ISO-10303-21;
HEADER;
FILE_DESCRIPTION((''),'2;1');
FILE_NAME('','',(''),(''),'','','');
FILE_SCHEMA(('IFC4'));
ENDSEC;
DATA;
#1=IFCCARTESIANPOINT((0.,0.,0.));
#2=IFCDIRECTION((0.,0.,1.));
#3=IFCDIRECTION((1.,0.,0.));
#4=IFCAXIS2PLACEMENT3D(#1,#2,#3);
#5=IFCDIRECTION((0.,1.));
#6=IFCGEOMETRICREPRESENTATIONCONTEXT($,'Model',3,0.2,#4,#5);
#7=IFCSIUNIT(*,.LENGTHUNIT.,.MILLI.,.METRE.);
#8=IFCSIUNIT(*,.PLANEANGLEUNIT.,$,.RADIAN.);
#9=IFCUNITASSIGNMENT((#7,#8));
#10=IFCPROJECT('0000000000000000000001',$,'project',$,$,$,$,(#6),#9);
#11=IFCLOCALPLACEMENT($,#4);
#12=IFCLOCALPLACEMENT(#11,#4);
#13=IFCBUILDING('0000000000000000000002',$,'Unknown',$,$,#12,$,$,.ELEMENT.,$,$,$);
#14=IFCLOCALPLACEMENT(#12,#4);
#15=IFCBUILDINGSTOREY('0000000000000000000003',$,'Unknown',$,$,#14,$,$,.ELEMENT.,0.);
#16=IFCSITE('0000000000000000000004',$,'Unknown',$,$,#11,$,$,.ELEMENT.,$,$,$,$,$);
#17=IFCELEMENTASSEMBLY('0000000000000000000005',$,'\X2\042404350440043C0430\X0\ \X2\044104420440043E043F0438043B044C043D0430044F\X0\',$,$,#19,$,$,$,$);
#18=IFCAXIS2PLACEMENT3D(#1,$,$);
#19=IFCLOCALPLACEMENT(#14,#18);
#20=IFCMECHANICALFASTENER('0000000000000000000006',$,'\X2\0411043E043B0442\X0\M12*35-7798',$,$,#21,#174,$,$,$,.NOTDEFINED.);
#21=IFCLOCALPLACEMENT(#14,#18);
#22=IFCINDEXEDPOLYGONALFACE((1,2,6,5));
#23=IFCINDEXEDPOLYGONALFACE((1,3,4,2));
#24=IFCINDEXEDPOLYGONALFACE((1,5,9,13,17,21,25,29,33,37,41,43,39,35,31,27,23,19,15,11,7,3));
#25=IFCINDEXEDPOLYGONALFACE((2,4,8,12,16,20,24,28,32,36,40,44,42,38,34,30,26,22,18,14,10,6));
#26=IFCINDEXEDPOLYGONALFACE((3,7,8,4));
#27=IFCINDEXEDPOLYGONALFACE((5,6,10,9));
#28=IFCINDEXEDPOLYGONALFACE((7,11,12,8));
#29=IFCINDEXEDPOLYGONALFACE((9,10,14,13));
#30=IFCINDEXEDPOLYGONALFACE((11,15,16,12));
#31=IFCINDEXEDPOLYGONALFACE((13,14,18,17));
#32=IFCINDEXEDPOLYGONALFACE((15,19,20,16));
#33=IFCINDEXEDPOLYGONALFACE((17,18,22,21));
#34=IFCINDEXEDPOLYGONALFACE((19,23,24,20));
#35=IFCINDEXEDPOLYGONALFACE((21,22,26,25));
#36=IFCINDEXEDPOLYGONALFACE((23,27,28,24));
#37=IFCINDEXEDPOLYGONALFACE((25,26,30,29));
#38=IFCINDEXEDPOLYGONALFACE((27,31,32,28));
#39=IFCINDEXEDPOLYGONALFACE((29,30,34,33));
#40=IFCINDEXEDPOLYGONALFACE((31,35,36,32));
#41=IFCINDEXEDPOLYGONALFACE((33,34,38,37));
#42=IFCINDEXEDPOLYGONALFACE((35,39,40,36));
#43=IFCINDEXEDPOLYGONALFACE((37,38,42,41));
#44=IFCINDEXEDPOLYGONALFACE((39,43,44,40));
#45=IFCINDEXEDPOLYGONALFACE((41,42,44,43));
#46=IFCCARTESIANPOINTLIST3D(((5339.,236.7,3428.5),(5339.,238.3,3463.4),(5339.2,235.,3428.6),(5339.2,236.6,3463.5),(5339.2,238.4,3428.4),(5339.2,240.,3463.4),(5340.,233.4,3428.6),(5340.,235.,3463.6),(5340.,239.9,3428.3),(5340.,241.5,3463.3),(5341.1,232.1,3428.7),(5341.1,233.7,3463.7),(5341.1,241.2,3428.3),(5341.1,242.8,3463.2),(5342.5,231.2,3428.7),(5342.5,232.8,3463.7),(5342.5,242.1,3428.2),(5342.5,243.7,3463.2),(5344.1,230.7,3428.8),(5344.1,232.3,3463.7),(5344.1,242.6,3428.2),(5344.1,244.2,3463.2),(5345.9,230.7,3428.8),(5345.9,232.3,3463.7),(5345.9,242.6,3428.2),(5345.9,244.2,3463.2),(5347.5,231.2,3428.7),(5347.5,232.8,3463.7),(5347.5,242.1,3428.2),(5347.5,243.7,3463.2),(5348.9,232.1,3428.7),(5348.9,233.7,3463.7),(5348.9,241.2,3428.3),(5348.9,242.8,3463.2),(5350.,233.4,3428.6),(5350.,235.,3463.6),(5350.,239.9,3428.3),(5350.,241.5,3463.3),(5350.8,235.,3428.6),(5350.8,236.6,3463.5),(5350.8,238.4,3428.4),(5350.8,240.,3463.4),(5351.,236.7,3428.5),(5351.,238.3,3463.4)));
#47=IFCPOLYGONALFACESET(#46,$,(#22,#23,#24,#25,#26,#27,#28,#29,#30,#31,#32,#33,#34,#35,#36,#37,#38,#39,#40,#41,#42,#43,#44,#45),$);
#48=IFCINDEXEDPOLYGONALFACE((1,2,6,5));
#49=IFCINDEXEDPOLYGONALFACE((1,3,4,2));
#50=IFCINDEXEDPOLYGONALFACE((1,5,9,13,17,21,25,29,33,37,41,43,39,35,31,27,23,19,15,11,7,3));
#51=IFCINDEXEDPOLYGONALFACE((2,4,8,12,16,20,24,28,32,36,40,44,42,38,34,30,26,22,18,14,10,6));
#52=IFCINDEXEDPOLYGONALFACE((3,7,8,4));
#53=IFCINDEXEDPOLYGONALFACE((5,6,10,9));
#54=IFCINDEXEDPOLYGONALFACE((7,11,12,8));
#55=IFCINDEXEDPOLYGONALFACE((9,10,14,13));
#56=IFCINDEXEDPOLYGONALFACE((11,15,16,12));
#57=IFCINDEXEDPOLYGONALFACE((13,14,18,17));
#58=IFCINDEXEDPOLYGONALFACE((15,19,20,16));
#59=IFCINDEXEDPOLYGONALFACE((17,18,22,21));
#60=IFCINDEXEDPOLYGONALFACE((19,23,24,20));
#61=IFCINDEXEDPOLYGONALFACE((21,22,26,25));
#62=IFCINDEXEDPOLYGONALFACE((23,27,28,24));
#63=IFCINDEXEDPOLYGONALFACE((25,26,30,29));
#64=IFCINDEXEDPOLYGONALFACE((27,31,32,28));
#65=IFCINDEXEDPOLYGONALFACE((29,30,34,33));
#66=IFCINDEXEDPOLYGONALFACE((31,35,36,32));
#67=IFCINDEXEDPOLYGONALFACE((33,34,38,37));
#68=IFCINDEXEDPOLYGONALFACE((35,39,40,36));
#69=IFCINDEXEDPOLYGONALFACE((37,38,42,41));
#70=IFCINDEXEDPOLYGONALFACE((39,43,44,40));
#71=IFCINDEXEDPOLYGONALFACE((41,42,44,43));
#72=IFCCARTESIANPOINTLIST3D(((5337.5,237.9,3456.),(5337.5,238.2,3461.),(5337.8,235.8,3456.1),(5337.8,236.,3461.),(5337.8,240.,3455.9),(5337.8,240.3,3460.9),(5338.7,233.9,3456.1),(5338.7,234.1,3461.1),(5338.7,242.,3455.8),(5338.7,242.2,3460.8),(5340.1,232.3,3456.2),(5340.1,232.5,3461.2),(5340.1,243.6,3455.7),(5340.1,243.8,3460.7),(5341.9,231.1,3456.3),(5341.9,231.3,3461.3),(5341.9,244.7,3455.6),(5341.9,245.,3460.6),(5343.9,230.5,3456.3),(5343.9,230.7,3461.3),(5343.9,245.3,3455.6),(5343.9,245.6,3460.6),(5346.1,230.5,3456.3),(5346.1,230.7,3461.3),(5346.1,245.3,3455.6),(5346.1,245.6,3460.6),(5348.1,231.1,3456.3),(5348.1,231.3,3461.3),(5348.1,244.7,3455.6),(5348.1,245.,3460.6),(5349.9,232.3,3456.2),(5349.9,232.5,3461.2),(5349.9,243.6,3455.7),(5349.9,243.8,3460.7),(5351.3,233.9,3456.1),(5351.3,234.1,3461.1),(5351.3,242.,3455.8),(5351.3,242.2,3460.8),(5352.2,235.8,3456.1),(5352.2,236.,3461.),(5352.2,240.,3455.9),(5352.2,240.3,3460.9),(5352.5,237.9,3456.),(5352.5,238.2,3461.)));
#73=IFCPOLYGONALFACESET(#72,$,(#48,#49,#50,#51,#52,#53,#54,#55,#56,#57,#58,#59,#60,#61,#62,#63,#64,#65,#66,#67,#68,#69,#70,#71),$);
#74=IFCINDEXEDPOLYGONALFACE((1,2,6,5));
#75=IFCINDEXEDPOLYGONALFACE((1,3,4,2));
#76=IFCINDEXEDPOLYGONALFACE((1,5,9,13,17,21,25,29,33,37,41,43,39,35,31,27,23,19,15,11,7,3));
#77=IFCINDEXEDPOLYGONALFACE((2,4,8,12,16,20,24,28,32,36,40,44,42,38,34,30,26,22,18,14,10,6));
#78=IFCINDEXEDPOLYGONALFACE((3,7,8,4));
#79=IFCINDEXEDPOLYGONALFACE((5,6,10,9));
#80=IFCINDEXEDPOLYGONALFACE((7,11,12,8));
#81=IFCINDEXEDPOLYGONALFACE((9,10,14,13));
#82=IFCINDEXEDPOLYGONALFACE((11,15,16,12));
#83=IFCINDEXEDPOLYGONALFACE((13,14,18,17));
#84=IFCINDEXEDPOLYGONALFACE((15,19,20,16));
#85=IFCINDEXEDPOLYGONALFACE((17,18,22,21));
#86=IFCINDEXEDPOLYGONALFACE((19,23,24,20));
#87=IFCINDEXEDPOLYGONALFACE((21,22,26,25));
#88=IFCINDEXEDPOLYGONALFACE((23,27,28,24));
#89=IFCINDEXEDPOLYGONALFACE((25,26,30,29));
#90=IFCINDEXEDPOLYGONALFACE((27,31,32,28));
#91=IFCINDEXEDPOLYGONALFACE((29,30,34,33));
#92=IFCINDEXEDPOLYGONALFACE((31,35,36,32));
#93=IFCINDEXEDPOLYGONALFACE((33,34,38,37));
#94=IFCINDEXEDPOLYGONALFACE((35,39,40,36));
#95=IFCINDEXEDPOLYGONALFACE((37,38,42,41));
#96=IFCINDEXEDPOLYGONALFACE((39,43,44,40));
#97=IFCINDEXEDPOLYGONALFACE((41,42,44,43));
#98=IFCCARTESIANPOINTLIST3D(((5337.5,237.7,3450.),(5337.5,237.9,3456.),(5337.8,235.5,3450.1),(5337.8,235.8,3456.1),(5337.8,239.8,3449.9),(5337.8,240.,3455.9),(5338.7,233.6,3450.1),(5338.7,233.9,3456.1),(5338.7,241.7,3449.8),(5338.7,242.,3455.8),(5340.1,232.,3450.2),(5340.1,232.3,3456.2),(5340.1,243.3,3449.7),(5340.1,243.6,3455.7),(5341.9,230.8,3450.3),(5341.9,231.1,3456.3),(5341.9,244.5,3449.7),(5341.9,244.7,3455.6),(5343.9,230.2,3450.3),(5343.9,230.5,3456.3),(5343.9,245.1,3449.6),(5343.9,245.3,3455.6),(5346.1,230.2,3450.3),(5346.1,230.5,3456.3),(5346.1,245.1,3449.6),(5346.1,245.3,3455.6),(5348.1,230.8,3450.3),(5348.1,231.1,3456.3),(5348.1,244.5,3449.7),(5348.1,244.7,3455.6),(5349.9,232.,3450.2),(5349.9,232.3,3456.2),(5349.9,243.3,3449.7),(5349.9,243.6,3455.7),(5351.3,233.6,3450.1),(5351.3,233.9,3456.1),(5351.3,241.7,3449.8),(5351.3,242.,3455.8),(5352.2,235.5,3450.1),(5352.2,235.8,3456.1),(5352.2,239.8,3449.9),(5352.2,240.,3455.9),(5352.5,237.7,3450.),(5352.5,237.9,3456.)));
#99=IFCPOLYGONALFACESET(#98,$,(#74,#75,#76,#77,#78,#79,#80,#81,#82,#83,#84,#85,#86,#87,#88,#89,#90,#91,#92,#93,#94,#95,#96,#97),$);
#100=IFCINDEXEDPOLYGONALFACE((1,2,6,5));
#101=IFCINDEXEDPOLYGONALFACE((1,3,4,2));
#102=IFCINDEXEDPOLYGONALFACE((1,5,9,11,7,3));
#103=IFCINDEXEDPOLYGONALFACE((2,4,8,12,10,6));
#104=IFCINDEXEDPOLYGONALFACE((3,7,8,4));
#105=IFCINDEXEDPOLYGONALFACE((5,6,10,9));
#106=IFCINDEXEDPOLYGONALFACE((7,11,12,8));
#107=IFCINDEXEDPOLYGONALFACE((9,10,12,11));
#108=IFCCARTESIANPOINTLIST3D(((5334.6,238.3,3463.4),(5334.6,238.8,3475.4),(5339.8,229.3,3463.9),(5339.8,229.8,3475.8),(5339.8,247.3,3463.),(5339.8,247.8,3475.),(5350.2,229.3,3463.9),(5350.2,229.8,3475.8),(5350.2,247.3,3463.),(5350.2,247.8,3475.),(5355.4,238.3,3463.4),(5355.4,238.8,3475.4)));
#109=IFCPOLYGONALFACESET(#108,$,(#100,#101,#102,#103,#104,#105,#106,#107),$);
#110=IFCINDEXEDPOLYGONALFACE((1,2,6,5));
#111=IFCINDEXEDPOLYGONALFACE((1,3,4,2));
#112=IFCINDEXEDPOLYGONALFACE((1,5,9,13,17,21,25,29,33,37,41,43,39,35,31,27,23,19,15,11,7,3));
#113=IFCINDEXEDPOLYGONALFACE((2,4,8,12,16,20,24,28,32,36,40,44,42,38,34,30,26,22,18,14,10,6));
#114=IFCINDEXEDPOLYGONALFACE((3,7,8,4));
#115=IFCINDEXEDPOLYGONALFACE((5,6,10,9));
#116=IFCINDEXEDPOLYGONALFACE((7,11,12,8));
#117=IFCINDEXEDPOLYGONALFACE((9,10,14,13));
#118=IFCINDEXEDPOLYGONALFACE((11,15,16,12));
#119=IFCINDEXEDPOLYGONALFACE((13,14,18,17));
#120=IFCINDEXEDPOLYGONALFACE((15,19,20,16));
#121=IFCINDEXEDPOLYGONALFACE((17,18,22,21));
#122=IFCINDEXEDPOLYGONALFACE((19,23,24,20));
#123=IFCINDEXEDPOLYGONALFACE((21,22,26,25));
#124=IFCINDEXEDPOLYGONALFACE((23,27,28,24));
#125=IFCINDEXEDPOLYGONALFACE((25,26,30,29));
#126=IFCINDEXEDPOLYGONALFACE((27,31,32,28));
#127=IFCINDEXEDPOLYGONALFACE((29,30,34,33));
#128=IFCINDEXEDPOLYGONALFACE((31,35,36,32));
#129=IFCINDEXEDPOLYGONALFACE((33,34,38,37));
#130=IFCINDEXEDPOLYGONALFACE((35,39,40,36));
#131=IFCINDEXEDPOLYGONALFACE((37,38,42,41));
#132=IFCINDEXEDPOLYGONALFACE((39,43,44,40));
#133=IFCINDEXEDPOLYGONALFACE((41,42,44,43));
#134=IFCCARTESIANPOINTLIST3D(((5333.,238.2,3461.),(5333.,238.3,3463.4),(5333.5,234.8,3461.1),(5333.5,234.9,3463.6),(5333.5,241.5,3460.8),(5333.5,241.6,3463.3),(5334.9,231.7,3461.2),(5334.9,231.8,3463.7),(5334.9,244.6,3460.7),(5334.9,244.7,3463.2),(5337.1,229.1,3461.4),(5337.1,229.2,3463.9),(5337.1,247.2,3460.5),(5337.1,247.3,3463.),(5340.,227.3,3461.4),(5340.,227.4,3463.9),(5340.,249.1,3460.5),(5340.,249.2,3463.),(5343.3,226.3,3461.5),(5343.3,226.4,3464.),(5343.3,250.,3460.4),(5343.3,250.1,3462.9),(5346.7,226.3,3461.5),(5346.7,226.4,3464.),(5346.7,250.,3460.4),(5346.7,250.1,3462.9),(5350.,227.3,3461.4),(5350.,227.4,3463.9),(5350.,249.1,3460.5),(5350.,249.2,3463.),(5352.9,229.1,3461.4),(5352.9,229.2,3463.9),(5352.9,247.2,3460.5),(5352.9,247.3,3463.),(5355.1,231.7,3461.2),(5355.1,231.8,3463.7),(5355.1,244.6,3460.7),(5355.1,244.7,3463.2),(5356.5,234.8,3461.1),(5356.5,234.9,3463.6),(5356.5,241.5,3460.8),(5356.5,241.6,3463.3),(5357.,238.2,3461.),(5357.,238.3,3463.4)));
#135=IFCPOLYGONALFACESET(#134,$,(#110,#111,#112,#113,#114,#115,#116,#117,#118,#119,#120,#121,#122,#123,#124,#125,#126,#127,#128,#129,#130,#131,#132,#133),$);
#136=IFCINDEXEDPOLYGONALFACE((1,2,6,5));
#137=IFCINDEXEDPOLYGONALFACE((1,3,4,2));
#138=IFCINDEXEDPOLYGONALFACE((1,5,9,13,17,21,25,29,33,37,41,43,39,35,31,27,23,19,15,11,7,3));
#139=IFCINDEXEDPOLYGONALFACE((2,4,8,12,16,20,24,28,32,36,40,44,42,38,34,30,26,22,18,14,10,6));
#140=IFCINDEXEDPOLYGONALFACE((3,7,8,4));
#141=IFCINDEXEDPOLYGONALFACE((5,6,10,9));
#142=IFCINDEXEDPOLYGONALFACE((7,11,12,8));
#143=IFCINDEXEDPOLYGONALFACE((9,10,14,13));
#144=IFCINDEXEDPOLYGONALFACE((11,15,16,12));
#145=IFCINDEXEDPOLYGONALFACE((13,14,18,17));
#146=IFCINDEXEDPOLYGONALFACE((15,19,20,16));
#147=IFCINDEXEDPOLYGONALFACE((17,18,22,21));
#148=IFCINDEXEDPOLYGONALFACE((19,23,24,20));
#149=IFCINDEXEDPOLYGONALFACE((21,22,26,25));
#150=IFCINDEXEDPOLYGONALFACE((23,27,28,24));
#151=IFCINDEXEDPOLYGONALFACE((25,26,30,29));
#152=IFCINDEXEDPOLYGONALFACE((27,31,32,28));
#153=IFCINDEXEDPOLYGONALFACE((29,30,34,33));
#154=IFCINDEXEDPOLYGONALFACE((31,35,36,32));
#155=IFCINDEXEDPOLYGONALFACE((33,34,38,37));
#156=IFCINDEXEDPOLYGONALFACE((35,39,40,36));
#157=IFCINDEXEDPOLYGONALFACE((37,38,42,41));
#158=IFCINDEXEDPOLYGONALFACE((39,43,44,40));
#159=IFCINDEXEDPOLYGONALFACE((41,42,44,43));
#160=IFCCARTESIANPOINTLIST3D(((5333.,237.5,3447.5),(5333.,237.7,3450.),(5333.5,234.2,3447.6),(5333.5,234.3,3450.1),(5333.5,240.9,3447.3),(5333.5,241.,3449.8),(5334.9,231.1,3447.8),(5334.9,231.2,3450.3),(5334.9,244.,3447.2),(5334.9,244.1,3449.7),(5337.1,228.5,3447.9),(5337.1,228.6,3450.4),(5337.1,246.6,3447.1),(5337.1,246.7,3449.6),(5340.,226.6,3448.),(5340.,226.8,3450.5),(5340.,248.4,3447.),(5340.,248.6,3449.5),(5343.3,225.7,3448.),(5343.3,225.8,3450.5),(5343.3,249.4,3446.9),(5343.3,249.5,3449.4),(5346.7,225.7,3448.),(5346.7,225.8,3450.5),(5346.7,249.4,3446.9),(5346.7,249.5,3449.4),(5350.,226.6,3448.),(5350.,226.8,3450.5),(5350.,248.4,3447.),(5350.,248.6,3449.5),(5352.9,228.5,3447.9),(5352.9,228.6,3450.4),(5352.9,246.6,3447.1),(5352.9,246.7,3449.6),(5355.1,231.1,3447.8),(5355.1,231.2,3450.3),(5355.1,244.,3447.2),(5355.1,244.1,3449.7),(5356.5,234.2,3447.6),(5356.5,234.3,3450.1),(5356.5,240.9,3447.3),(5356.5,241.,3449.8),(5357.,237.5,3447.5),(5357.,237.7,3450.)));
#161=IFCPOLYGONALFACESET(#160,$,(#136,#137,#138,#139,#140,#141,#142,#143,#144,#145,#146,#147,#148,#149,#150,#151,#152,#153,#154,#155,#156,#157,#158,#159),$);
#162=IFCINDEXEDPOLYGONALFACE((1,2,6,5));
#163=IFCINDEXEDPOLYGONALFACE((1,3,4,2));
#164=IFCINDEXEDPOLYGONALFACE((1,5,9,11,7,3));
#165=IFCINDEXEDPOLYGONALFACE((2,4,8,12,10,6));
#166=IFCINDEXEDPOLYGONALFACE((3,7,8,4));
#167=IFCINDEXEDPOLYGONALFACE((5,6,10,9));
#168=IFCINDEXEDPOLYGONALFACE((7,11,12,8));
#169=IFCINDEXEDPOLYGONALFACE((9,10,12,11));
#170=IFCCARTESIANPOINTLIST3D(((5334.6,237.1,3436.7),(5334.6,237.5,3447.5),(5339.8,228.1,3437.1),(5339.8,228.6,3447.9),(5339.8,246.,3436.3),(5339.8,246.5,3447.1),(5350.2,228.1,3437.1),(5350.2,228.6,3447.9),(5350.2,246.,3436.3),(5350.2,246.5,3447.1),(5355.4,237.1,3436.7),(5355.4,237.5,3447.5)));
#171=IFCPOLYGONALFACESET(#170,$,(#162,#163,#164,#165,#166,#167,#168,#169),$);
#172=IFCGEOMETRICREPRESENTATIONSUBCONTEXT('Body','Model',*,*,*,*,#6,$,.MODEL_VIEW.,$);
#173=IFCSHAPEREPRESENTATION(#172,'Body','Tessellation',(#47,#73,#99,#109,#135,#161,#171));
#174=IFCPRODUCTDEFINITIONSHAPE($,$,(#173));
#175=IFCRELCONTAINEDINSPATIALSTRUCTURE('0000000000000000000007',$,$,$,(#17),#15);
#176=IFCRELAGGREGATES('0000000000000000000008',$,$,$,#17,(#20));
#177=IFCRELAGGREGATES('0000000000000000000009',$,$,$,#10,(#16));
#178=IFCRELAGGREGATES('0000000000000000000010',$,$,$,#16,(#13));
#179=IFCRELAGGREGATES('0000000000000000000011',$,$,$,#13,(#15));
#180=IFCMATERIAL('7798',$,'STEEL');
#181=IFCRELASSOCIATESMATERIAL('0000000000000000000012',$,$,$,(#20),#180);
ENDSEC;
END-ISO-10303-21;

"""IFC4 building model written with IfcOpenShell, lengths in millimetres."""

from ifc_helpers import new_model, si_unit, direction, frame, origin_with_axes, place, context, subcontext, project, spatial, line, arc, indexed_curve, outline, extrude, source, transform, mapped, material, element, aggregate, save


model = new_model("IFC4")

# Units and contexts
model_context = context("Model", 3, precision=0.2, world=origin_with_axes(), true_north=direction((0.0, 1.0)))
body_context = subcontext(model_context, "Body", "Model", "MODEL_VIEW")
ifc_project = project(units=[si_unit("LENGTHUNIT", "METRE", prefix="MILLI"), si_unit("PLANEANGLEUNIT", "RADIAN")], contexts=[model_context])

# Site, building, storey
site_placement = place(None, origin_with_axes())
site = spatial("IfcSite", under=ifc_project, at=site_placement, Name="Unknown", CompositionType="ELEMENT")
building_placement = place(site_placement, origin_with_axes())
building = spatial("IfcBuilding", under=site, at=building_placement, Name="Unknown", CompositionType="ELEMENT")
storey_placement = place(building_placement, origin_with_axes())
storey = spatial("IfcBuildingStorey", under=building, at=storey_placement, Name="Unknown", CompositionType="ELEMENT", Elevation=0.0)

# Element assembly
assembly_1_placement = place(storey_placement, frame((5400.0, 88.6, 3426.7), z_axis=(1.0, 0.0, 0.0), x_axis=(0.0, 0.998969, -0.045408)))
assembly_1 = element("IfcElementAssembly", 1, at=assembly_1_placement, inside=storey, Name="Ферма стропильная")

# Mechanical fastener
ifc_material_1 = material(Name="7798", Category="STEEL")
shared_shape_1 = source(origin_with_axes(), body_context, "Body", "SweptSolid", [
    extrude(outline(indexed_curve([(6.0, 0.0), (0.0, 6.0), (-6.0, 0.0), (0.0, -6.0)], segments=[arc(1, 2, 3), arc(3, 4, 1)])), frame((0.0, 0.0, 7.5), z_axis=(0.0, 0.0, -1.0), x_axis=(0.0, 1.0, 0.0)), (0.0, 0.0, 1.0), 35.0),
    extrude(outline(indexed_curve([(7.5, 0.0), (0.0, 7.5), (-7.5, 0.0), (0.0, -7.5)], segments=[arc(1, 2, 3), arc(3, 4, 1)])), frame((0.0, 0.0, 5.0), z_axis=(0.0, 0.0, -1.0), x_axis=(0.0, 1.0, 0.0)), (0.0, 0.0, 1.0), 5.0),
    extrude(outline(indexed_curve([(7.5, 0.0), (0.0, 7.5), (-7.5, 0.0), (0.0, -7.5)], segments=[arc(1, 2, 3), arc(3, 4, 1)])), frame((0.0, 0.0, 0.0), z_axis=(0.0, 0.0, -1.0), x_axis=(0.0, 1.0, 0.0)), (0.0, 0.0, 1.0), 6.0),
    extrude(outline(indexed_curve([(10.4, 0.0), (5.2, 9.0), (-5.2, 9.0), (-10.4, 0.0), (-5.2, -9.0), (5.2, -9.0)], segments=[line(1, 2, 3, 4, 5, 6, 1)])), frame((0.0, 0.0, 19.5), z_axis=(0.0, 0.0, -1.0), x_axis=(0.0, 1.0, 0.0)), (0.0, 0.0, 1.0), 12.0),
    extrude(outline(indexed_curve([(12.0, 0.0), (0.0, 12.0), (-12.0, 0.0), (0.0, -12.0)], segments=[arc(1, 2, 3), arc(3, 4, 1)])), frame((0.0, 0.0, 7.5), z_axis=(0.0, 0.0, -1.0), x_axis=(0.0, 1.0, 0.0)), (0.0, 0.0, 1.0), 2.5),
    extrude(outline(indexed_curve([(12.0, 0.0), (0.0, 12.0), (-12.0, 0.0), (0.0, -12.0)], segments=[arc(1, 2, 3), arc(3, 4, 1)])), frame((0.0, 0.0, -6.0), z_axis=(0.0, 0.0, -1.0), x_axis=(0.0, 1.0, 0.0)), (0.0, 0.0, 1.0), 2.5),
    extrude(outline(indexed_curve([(10.4, 0.0), (5.2, 9.0), (-5.2, 9.0), (-10.4, 0.0), (-5.2, -9.0), (5.2, -9.0)], segments=[line(1, 2, 3, 4, 5, 6, 1)])), frame((0.0, 0.0, -8.5), z_axis=(0.0, 0.0, -1.0), x_axis=(0.0, 1.0, 0.0)), (0.0, 0.0, 1.0), 10.8),
])
mechanical_fastener_1_placement = place(assembly_1_placement, frame((147.8, 36.0, -55.0), z_axis=(0.0, 1.0, 0.0), x_axis=(-1.0, 0.0, 0.0)))
mechanical_fastener_1 = element("IfcMechanicalFastener", 2, at=mechanical_fastener_1_placement, material=ifc_material_1, Name="БолтM12*35-7798", PredefinedType="NOTDEFINED", context=body_context, shape_type="MappedRepresentation", body=[
    mapped(shared_shape_1, transform((0.0, 0.0, 0.0))),
])
aggregate(assembly_1, [mechanical_fastener_1])

save(model, "model.ifc")
